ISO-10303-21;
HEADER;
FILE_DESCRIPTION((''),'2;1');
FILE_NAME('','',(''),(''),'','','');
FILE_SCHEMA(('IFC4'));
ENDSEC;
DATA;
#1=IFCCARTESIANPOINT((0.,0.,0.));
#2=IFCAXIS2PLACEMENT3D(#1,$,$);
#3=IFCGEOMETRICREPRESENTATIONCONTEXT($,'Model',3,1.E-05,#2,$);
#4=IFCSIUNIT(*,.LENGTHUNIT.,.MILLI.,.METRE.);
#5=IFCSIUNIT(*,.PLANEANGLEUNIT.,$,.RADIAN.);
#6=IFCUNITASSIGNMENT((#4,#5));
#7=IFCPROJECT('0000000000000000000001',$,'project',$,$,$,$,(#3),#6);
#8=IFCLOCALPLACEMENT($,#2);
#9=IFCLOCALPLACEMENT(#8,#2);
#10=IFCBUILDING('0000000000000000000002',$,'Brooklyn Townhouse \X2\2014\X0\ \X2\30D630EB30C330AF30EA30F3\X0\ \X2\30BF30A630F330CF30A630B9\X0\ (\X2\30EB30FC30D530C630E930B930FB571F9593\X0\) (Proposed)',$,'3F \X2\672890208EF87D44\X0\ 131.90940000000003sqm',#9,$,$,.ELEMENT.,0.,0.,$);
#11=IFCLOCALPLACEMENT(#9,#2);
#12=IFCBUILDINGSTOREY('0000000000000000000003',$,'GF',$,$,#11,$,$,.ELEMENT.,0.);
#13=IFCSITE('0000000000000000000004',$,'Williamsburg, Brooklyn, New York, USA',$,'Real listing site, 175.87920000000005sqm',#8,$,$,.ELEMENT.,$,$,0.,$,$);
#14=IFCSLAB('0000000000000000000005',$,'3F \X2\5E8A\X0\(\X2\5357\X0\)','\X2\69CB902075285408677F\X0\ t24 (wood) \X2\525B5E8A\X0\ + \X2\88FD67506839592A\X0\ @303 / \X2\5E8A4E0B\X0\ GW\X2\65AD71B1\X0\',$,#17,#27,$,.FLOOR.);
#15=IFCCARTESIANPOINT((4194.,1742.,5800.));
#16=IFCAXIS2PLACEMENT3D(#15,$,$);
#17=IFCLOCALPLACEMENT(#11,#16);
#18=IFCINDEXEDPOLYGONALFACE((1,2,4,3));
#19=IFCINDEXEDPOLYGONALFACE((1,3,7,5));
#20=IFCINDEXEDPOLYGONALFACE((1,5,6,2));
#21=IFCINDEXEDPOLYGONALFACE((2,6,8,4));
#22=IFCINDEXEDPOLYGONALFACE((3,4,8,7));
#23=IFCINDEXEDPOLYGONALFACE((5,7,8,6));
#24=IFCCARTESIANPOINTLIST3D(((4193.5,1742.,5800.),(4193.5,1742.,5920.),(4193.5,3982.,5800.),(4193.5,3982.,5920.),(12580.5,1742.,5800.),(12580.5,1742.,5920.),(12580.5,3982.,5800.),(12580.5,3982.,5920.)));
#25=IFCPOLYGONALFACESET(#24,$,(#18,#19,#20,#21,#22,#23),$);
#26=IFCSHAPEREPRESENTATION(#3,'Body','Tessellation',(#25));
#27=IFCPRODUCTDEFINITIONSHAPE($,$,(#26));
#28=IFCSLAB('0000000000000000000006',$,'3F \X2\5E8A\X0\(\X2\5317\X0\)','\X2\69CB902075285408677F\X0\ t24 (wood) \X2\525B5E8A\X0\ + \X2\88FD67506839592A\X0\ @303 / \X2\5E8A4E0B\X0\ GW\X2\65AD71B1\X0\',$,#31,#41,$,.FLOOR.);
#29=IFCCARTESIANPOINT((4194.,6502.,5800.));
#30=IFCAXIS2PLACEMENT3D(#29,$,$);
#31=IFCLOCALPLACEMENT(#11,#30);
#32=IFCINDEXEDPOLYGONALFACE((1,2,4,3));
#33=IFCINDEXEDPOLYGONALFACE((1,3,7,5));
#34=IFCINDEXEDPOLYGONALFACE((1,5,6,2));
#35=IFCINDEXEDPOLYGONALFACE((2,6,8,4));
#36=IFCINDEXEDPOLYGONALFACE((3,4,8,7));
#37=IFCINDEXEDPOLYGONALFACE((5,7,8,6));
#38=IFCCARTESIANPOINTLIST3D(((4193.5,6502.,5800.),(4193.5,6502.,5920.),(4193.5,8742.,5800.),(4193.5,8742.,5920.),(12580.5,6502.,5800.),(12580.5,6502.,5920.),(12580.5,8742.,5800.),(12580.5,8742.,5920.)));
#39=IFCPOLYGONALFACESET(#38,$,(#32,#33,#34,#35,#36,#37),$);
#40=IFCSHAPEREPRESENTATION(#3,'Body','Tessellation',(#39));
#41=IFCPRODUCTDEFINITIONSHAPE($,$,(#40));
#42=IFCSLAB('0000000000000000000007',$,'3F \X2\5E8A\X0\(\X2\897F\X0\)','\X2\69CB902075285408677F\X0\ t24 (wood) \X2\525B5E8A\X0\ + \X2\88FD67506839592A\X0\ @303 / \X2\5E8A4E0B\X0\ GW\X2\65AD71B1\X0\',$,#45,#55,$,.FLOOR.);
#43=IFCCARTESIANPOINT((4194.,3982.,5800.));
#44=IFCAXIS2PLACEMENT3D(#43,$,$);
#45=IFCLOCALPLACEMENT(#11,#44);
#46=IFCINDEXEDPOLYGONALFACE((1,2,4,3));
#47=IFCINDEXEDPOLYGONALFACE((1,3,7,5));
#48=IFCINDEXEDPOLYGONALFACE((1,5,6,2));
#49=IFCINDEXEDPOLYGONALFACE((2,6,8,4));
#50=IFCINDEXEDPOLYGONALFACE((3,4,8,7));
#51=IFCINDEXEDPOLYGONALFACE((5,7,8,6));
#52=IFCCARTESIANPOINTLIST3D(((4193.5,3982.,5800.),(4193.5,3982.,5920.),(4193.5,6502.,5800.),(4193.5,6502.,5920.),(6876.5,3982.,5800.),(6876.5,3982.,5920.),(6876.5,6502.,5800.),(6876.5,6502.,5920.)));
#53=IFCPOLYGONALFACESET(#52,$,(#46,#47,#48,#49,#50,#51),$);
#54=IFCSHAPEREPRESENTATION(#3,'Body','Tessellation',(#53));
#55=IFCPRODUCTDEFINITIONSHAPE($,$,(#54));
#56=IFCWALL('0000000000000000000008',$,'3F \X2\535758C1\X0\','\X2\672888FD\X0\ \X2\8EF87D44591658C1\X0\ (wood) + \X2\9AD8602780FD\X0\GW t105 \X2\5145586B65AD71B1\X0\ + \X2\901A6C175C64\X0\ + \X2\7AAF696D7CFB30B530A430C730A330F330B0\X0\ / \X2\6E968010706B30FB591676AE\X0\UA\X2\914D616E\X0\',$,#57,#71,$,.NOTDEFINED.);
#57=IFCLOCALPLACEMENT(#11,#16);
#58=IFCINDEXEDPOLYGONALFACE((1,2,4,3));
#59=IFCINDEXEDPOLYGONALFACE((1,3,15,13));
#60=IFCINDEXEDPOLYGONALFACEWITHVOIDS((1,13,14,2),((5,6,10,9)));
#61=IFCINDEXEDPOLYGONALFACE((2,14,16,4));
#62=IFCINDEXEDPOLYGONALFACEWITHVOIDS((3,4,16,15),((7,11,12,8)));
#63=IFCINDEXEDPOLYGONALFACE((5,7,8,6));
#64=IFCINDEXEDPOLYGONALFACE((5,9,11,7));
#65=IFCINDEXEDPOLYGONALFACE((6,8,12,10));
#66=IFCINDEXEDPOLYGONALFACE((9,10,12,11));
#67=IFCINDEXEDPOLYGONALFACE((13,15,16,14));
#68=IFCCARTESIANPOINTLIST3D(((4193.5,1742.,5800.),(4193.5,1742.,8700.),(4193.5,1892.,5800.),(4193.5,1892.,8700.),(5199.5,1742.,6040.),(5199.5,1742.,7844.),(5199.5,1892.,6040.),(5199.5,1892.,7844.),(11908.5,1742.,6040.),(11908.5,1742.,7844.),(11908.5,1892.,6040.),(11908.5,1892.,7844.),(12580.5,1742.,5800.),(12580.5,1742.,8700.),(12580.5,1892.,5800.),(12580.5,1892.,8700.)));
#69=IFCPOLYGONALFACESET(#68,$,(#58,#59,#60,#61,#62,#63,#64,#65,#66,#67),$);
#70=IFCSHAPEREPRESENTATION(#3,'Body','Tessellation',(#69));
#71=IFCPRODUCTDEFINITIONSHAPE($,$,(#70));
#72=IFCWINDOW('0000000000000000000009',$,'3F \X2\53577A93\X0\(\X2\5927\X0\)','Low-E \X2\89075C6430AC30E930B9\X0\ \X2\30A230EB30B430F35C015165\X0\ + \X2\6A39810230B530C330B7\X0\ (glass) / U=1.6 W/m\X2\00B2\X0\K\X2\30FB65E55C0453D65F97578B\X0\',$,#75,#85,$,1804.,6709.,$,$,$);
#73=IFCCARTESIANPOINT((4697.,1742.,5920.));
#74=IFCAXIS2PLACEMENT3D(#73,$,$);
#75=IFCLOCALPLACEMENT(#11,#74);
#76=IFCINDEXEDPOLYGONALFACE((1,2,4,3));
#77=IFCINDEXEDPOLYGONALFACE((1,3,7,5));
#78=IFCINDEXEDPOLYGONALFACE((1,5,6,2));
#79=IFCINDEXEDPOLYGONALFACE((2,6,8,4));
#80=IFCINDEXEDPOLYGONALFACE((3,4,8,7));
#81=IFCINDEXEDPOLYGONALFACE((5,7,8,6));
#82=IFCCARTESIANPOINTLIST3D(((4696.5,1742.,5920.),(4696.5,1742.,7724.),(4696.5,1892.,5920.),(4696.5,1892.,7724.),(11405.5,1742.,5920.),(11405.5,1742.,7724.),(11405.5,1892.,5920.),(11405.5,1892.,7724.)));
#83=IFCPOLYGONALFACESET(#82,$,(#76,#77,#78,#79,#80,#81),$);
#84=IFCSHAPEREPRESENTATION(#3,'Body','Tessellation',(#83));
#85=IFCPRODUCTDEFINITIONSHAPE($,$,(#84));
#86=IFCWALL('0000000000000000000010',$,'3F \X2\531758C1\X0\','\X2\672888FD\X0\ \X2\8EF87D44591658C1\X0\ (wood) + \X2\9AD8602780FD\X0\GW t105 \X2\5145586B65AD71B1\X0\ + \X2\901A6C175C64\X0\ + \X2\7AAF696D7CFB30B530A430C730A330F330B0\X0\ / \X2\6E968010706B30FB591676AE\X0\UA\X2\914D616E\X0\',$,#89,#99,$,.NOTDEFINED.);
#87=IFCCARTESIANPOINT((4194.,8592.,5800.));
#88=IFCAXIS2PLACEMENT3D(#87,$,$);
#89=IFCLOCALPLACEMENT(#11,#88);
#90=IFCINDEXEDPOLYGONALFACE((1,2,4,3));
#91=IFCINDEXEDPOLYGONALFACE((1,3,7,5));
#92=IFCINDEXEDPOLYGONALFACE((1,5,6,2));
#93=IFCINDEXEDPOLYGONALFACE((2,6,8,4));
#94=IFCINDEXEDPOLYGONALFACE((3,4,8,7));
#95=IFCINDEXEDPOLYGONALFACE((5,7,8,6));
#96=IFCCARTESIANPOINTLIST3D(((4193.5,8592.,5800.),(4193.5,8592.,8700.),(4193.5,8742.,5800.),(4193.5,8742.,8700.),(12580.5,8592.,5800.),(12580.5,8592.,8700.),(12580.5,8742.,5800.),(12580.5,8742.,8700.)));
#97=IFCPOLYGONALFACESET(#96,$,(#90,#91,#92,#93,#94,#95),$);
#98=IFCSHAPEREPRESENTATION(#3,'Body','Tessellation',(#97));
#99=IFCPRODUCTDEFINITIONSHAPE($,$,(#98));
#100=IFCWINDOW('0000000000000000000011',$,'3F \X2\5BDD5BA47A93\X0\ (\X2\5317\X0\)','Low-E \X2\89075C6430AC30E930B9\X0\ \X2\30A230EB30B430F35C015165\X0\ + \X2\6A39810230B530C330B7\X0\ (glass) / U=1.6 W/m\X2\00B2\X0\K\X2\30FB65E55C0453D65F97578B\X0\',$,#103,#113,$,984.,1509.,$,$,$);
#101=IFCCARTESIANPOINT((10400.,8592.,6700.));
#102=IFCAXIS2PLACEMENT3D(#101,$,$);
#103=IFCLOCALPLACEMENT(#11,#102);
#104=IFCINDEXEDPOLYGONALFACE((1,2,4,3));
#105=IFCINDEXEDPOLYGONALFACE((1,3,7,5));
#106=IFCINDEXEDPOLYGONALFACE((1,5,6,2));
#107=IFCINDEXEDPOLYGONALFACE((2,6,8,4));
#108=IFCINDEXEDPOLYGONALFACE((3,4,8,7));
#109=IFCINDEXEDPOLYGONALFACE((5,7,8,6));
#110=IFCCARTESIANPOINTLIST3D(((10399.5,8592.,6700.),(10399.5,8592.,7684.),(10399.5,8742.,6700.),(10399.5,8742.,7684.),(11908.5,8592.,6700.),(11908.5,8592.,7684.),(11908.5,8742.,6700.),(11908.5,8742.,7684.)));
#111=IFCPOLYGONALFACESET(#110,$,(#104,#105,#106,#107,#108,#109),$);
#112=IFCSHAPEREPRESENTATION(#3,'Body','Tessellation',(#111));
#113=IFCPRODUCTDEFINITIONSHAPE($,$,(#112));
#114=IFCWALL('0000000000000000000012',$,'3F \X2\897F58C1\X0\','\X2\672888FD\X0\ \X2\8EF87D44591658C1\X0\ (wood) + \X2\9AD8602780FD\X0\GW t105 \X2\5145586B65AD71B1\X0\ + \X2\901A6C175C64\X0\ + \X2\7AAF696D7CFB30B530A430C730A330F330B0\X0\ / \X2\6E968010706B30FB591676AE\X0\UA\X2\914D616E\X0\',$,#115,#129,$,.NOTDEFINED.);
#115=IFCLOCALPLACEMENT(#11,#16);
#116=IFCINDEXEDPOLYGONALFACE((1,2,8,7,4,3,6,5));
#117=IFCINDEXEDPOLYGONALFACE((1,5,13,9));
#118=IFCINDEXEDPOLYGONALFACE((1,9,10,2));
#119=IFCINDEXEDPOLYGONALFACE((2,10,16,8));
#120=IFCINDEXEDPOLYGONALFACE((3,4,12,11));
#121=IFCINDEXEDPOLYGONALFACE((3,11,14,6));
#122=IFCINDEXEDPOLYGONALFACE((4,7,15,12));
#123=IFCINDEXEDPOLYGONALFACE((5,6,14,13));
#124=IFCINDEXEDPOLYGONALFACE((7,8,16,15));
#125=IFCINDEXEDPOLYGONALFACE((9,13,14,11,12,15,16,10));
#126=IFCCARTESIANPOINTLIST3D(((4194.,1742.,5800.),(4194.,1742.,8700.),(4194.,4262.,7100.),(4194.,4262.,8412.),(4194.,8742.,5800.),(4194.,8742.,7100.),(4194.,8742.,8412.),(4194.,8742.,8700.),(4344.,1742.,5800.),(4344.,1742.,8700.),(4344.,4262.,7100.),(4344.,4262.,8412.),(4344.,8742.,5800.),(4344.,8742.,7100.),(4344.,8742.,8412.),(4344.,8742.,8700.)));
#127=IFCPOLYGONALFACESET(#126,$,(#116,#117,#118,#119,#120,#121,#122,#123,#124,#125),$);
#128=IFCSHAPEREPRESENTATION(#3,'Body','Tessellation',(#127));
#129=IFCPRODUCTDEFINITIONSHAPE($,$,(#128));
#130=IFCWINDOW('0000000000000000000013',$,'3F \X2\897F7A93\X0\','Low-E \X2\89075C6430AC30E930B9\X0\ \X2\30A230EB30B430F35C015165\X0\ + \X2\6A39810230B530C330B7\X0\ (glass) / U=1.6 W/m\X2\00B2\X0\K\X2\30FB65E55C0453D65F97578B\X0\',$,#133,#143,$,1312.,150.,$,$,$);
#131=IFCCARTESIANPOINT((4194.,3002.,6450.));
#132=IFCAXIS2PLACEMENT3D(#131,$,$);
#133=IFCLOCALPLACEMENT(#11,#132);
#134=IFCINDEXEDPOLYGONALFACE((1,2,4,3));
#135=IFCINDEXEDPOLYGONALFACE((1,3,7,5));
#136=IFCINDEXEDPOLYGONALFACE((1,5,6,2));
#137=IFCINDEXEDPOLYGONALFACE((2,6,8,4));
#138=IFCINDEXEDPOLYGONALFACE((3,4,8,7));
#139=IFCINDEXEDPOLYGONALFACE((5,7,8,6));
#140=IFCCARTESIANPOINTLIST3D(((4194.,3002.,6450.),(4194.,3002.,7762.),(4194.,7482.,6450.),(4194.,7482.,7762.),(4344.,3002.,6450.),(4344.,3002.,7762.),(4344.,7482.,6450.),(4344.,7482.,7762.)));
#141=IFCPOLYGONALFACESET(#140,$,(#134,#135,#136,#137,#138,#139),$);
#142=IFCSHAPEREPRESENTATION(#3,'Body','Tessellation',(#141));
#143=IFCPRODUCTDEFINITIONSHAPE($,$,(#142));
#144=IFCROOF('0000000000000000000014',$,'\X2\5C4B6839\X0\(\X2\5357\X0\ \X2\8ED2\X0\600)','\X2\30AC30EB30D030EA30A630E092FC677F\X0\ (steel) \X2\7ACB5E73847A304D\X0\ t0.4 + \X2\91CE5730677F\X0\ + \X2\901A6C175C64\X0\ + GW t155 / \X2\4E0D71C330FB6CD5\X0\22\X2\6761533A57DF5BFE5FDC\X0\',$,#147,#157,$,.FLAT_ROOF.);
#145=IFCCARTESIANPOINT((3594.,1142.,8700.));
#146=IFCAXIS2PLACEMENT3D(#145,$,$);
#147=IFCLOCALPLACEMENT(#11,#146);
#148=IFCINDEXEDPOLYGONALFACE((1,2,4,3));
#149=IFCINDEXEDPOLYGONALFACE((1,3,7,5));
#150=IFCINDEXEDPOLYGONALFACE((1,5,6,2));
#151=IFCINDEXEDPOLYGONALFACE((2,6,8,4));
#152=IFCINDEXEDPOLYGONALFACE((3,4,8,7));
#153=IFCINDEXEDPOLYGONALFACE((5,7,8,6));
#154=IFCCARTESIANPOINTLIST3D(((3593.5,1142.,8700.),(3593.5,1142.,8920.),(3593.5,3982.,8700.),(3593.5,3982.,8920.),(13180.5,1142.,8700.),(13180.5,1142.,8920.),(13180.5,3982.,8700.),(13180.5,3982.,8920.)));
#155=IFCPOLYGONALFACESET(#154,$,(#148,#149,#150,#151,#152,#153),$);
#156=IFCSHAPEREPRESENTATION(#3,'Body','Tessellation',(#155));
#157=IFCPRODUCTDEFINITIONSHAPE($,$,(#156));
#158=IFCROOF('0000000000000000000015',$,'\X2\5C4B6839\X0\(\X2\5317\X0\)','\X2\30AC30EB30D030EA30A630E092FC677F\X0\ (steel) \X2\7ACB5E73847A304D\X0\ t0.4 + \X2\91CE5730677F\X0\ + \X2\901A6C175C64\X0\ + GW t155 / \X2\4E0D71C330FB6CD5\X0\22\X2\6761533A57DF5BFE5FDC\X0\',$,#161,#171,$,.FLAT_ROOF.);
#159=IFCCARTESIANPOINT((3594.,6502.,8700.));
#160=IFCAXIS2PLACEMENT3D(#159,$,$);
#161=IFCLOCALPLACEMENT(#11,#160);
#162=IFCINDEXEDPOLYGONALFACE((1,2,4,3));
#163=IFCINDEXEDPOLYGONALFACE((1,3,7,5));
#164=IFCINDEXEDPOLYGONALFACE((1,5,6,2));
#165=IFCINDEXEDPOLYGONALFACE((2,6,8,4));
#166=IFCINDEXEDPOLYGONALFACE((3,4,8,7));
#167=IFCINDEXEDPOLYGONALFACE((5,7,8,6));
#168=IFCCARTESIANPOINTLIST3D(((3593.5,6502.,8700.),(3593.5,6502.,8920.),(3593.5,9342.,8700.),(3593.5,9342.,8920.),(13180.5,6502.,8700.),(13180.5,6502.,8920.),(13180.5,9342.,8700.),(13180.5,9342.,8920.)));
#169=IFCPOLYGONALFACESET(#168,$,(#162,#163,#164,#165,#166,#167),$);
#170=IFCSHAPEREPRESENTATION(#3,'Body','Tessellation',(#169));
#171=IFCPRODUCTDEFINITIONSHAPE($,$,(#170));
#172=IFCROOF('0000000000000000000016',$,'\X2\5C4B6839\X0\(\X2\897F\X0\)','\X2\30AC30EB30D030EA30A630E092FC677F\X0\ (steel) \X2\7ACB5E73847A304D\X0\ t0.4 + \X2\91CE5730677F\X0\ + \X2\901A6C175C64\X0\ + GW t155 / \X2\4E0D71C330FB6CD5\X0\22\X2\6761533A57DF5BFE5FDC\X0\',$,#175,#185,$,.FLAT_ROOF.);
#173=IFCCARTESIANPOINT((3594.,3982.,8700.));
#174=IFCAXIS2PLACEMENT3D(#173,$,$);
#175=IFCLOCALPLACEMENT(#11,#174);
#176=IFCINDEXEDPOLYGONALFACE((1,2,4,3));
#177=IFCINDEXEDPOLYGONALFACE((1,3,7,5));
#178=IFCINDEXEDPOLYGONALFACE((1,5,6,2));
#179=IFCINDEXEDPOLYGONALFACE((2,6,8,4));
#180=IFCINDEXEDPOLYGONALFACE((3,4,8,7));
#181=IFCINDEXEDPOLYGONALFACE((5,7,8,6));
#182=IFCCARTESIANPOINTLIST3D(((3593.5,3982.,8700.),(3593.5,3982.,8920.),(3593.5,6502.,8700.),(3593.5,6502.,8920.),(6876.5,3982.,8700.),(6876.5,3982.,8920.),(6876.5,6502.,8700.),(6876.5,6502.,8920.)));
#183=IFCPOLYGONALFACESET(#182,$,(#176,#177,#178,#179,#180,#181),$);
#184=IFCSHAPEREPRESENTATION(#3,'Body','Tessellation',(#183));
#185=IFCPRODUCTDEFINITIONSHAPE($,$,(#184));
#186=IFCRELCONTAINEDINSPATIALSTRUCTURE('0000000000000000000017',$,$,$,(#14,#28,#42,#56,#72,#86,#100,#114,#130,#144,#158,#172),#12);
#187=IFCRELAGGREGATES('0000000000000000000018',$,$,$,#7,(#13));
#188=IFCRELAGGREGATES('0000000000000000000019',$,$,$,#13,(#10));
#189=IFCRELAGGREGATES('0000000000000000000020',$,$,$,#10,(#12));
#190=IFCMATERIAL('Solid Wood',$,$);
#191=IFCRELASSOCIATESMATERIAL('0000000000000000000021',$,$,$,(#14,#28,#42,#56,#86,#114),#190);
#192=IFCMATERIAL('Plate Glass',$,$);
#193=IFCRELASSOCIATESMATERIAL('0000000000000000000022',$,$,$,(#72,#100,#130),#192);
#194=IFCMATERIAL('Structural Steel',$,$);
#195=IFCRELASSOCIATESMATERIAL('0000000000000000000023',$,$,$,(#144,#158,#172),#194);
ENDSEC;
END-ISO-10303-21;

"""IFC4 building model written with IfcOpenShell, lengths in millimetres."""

from ifc_helpers import new_model, si_unit, frame, frame_2d, origin, place, context, project, spatial, rectangle, extrude, material, element, fill, save


model = new_model("IFC4")

# Units and contexts
model_context = context("Model", 3, precision=1e-05, world=origin())
ifc_project = project(units=[si_unit("LENGTHUNIT", "METRE", prefix="MILLI"), si_unit("PLANEANGLEUNIT", "RADIAN")], contexts=[model_context])

# Site, building, storey
site_placement = place(None, origin())
site = spatial("IfcSite", under=ifc_project, at=site_placement, Name="Williamsburg, Brooklyn, New York, USA", ObjectType="Real listing site, 175.87920000000005sqm", CompositionType="ELEMENT", RefElevation=0.0)
building_placement = place(site_placement, origin())
building = spatial("IfcBuilding", under=site, at=building_placement, Name="Brooklyn Townhouse — ブルックリン タウンハウス (ルーフテラス・土間) (Proposed)", ObjectType="3F 木造軸組 131.90940000000003sqm", CompositionType="ELEMENT", ElevationOfRefHeight=0.0, ElevationOfTerrain=0.0)
storey_placement = place(building_placement, origin())
storey = spatial("IfcBuildingStorey", under=building, at=storey_placement, Name="GF", CompositionType="ELEMENT", Elevation=0.0)

# Slabs
ifc_material_1 = material(Name="Solid Wood")
slab_1_placement = place(storey_placement, frame((4194.0, 1742.0, 5800.0)))
element("IfcSlab", 1, at=slab_1_placement, inside=storey, material=ifc_material_1, Name="3F 床(南)", Description="構造用合板 t24 (wood) 剛床 + 製材根太 @303 / 床下 GW断熱", PredefinedType="FLOOR", context=model_context, shape_type="SweptSolid", body=[
    extrude(rectangle(XDim=8387.0, YDim=2240.0, at=frame_2d((4193.0, 1120.0))), frame((4194.0, 1742.0, 5800.0)), (0.0, 0.0, 1.0), 120.0),
])
slab_2_placement = place(storey_placement, frame((4194.0, 6502.0, 5800.0)))
element("IfcSlab", 2, at=slab_2_placement, inside=storey, material=ifc_material_1, Name="3F 床(北)", Description="構造用合板 t24 (wood) 剛床 + 製材根太 @303 / 床下 GW断熱", PredefinedType="FLOOR", context=model_context, shape_type="SweptSolid", body=[
    extrude(rectangle(XDim=8387.0, YDim=2240.0, at=frame_2d((4193.0, 1120.0))), frame((4194.0, 6502.0, 5800.0)), (0.0, 0.0, 1.0), 120.0),
])
slab_3_placement = place(storey_placement, frame((4194.0, 3982.0, 5800.0)))
element("IfcSlab", 3, at=slab_3_placement, inside=storey, material=ifc_material_1, Name="3F 床(西)", Description="構造用合板 t24 (wood) 剛床 + 製材根太 @303 / 床下 GW断熱", PredefinedType="FLOOR", context=model_context, shape_type="SweptSolid", body=[
    extrude(rectangle(XDim=2683.0, YDim=2520.0, at=frame_2d((1341.0, 1260.0))), frame((4194.0, 3982.0, 5800.0)), (0.0, 0.0, 1.0), 120.0),
])

# Walls, openings, windows
wall_1_placement = place(storey_placement, frame((4194.0, 1742.0, 5800.0)))
wall_1 = element("IfcWall", 4, at=wall_1_placement, inside=storey, material=ifc_material_1, Name="3F 南壁", Description="木製 軸組外壁 (wood) + 高性能GW t105 充填断熱 + 通気層 + 窯業系サイディング / 準耐火・外皮UA配慮", PredefinedType="NOTDEFINED", context=model_context, shape_type="SweptSolid", body=[
    extrude(rectangle(XDim=8387.0, YDim=150.0, at=frame_2d((4193.0, 75.0))), frame((4194.0, 1742.0, 5800.0)), (0.0, 0.0, 1.0), 2900.0),
])
opening_1_placement = place(storey_placement, frame((4697.0, 1742.0, 5920.0)))
opening_1 = element("IfcOpeningElement", 5, at=opening_1_placement, cuts=wall_1, PredefinedType="NOTDEFINED", context=model_context, shape_type="SweptSolid", body=[
    extrude(rectangle(XDim=6709.0, YDim=150.0, at=frame_2d((3354.0, 75.0))), frame((4697.0, 1742.0, 5920.0)), (0.0, 0.0, 1.0), 1804.0),
])
ifc_material_2 = material(Name="Plate Glass")
window_1_placement = place(storey_placement, frame((4697.0, 1742.0, 5920.0)))
window_1 = element("IfcWindow", 6, at=window_1_placement, inside=storey, material=ifc_material_2, Name="3F 南窓(大)", Description="Low-E 複層ガラス アルゴン封入 + 樹脂サッシ (glass) / U=1.6 W/m²K・日射取得型", OverallHeight=1804.0, OverallWidth=6709.0, context=model_context, shape_type="SweptSolid", body=[
    extrude(rectangle(XDim=6709.0, YDim=150.0, at=frame_2d((3354.0, 75.0))), frame((4697.0, 1742.0, 5920.0)), (0.0, 0.0, 1.0), 1804.0),
])
fill(opening_1, window_1)
wall_2_placement = place(storey_placement, frame((4194.0, 8592.0, 5800.0)))
wall_2 = element("IfcWall", 7, at=wall_2_placement, inside=storey, material=ifc_material_1, Name="3F 北壁", Description="木製 軸組外壁 (wood) + 高性能GW t105 充填断熱 + 通気層 + 窯業系サイディング / 準耐火・外皮UA配慮", PredefinedType="NOTDEFINED", context=model_context, shape_type="SweptSolid", body=[
    extrude(rectangle(XDim=8387.0, YDim=150.0, at=frame_2d((4193.0, 75.0))), frame((4194.0, 8592.0, 5800.0)), (0.0, 0.0, 1.0), 2900.0),
])
opening_2_placement = place(storey_placement, frame((10400.0, 8592.0, 6700.0)))
opening_2 = element("IfcOpeningElement", 8, at=opening_2_placement, cuts=wall_2, PredefinedType="NOTDEFINED", context=model_context, shape_type="SweptSolid", body=[
    extrude(rectangle(XDim=1509.0, YDim=150.0, at=frame_2d((754.0, 75.0))), frame((10400.0, 8592.0, 6700.0)), (0.0, 0.0, 1.0), 984.0),
])
window_2_placement = place(storey_placement, frame((10400.0, 8592.0, 6700.0)))
window_2 = element("IfcWindow", 9, at=window_2_placement, inside=storey, material=ifc_material_2, Name="3F 寝室窓 (北)", Description="Low-E 複層ガラス アルゴン封入 + 樹脂サッシ (glass) / U=1.6 W/m²K・日射取得型", OverallHeight=984.0, OverallWidth=1509.0, context=model_context, shape_type="SweptSolid", body=[
    extrude(rectangle(XDim=1509.0, YDim=150.0, at=frame_2d((754.0, 75.0))), frame((10400.0, 8592.0, 6700.0)), (0.0, 0.0, 1.0), 984.0),
])
fill(opening_2, window_2)
wall_3_placement = place(storey_placement, frame((4194.0, 1742.0, 5800.0)))
wall_3 = element("IfcWall", 10, at=wall_3_placement, inside=storey, material=ifc_material_1, Name="3F 西壁", Description="木製 軸組外壁 (wood) + 高性能GW t105 充填断熱 + 通気層 + 窯業系サイディング / 準耐火・外皮UA配慮", PredefinedType="NOTDEFINED", context=model_context, shape_type="SweptSolid", body=[
    extrude(rectangle(XDim=150.0, YDim=7000.0, at=frame_2d((75.0, 3500.0))), frame((4194.0, 1742.0, 5800.0)), (0.0, 0.0, 1.0), 2900.0),
])
opening_3_placement = place(storey_placement, frame((4194.0, 3002.0, 6450.0)))
opening_3 = element("IfcOpeningElement", 11, at=opening_3_placement, cuts=wall_3, PredefinedType="NOTDEFINED", context=model_context, shape_type="SweptSolid", body=[
    extrude(rectangle(XDim=150.0, YDim=4480.0, at=frame_2d((75.0, 2240.0))), frame((4194.0, 3002.0, 6450.0)), (0.0, 0.0, 1.0), 1312.0),
])
window_3_placement = place(storey_placement, frame((4194.0, 3002.0, 6450.0)))
window_3 = element("IfcWindow", 12, at=window_3_placement, inside=storey, material=ifc_material_2, Name="3F 西窓", Description="Low-E 複層ガラス アルゴン封入 + 樹脂サッシ (glass) / U=1.6 W/m²K・日射取得型", OverallHeight=1312.0, OverallWidth=150.0, context=model_context, shape_type="SweptSolid", body=[
    extrude(rectangle(XDim=150.0, YDim=4480.0, at=frame_2d((75.0, 2240.0))), frame((4194.0, 3002.0, 6450.0)), (0.0, 0.0, 1.0), 1312.0),
])
fill(opening_3, window_3)

# Roofs
ifc_material_3 = material(Name="Structural Steel")
roof_1_placement = place(storey_placement, frame((3594.0, 1142.0, 8700.0)))
element("IfcRoof", 13, at=roof_1_placement, inside=storey, material=ifc_material_3, Name="屋根(南 軒600)", Description="ガルバリウム鋼板 (steel) 立平葺き t0.4 + 野地板 + 通気層 + GW t155 / 不燃・法22条区域対応", PredefinedType="FLAT_ROOF", context=model_context, shape_type="SweptSolid", body=[
    extrude(rectangle(XDim=9587.0, YDim=2840.0, at=frame_2d((4793.0, 1420.0))), frame((3594.0, 1142.0, 8700.0)), (0.0, 0.0, 1.0), 220.0),
])
roof_2_placement = place(storey_placement, frame((3594.0, 6502.0, 8700.0)))
element("IfcRoof", 14, at=roof_2_placement, inside=storey, material=ifc_material_3, Name="屋根(北)", Description="ガルバリウム鋼板 (steel) 立平葺き t0.4 + 野地板 + 通気層 + GW t155 / 不燃・法22条区域対応", PredefinedType="FLAT_ROOF", context=model_context, shape_type="SweptSolid", body=[
    extrude(rectangle(XDim=9587.0, YDim=2840.0, at=frame_2d((4793.0, 1420.0))), frame((3594.0, 6502.0, 8700.0)), (0.0, 0.0, 1.0), 220.0),
])
roof_3_placement = place(storey_placement, frame((3594.0, 3982.0, 8700.0)))
element("IfcRoof", 15, at=roof_3_placement, inside=storey, material=ifc_material_3, Name="屋根(西)", Description="ガルバリウム鋼板 (steel) 立平葺き t0.4 + 野地板 + 通気層 + GW t155 / 不燃・法22条区域対応", PredefinedType="FLAT_ROOF", context=model_context, shape_type="SweptSolid", body=[
    extrude(rectangle(XDim=3283.0, YDim=2520.0, at=frame_2d((1641.0, 1260.0))), frame((3594.0, 3982.0, 8700.0)), (0.0, 0.0, 1.0), 220.0),
])

save(model, "model.ifc")
